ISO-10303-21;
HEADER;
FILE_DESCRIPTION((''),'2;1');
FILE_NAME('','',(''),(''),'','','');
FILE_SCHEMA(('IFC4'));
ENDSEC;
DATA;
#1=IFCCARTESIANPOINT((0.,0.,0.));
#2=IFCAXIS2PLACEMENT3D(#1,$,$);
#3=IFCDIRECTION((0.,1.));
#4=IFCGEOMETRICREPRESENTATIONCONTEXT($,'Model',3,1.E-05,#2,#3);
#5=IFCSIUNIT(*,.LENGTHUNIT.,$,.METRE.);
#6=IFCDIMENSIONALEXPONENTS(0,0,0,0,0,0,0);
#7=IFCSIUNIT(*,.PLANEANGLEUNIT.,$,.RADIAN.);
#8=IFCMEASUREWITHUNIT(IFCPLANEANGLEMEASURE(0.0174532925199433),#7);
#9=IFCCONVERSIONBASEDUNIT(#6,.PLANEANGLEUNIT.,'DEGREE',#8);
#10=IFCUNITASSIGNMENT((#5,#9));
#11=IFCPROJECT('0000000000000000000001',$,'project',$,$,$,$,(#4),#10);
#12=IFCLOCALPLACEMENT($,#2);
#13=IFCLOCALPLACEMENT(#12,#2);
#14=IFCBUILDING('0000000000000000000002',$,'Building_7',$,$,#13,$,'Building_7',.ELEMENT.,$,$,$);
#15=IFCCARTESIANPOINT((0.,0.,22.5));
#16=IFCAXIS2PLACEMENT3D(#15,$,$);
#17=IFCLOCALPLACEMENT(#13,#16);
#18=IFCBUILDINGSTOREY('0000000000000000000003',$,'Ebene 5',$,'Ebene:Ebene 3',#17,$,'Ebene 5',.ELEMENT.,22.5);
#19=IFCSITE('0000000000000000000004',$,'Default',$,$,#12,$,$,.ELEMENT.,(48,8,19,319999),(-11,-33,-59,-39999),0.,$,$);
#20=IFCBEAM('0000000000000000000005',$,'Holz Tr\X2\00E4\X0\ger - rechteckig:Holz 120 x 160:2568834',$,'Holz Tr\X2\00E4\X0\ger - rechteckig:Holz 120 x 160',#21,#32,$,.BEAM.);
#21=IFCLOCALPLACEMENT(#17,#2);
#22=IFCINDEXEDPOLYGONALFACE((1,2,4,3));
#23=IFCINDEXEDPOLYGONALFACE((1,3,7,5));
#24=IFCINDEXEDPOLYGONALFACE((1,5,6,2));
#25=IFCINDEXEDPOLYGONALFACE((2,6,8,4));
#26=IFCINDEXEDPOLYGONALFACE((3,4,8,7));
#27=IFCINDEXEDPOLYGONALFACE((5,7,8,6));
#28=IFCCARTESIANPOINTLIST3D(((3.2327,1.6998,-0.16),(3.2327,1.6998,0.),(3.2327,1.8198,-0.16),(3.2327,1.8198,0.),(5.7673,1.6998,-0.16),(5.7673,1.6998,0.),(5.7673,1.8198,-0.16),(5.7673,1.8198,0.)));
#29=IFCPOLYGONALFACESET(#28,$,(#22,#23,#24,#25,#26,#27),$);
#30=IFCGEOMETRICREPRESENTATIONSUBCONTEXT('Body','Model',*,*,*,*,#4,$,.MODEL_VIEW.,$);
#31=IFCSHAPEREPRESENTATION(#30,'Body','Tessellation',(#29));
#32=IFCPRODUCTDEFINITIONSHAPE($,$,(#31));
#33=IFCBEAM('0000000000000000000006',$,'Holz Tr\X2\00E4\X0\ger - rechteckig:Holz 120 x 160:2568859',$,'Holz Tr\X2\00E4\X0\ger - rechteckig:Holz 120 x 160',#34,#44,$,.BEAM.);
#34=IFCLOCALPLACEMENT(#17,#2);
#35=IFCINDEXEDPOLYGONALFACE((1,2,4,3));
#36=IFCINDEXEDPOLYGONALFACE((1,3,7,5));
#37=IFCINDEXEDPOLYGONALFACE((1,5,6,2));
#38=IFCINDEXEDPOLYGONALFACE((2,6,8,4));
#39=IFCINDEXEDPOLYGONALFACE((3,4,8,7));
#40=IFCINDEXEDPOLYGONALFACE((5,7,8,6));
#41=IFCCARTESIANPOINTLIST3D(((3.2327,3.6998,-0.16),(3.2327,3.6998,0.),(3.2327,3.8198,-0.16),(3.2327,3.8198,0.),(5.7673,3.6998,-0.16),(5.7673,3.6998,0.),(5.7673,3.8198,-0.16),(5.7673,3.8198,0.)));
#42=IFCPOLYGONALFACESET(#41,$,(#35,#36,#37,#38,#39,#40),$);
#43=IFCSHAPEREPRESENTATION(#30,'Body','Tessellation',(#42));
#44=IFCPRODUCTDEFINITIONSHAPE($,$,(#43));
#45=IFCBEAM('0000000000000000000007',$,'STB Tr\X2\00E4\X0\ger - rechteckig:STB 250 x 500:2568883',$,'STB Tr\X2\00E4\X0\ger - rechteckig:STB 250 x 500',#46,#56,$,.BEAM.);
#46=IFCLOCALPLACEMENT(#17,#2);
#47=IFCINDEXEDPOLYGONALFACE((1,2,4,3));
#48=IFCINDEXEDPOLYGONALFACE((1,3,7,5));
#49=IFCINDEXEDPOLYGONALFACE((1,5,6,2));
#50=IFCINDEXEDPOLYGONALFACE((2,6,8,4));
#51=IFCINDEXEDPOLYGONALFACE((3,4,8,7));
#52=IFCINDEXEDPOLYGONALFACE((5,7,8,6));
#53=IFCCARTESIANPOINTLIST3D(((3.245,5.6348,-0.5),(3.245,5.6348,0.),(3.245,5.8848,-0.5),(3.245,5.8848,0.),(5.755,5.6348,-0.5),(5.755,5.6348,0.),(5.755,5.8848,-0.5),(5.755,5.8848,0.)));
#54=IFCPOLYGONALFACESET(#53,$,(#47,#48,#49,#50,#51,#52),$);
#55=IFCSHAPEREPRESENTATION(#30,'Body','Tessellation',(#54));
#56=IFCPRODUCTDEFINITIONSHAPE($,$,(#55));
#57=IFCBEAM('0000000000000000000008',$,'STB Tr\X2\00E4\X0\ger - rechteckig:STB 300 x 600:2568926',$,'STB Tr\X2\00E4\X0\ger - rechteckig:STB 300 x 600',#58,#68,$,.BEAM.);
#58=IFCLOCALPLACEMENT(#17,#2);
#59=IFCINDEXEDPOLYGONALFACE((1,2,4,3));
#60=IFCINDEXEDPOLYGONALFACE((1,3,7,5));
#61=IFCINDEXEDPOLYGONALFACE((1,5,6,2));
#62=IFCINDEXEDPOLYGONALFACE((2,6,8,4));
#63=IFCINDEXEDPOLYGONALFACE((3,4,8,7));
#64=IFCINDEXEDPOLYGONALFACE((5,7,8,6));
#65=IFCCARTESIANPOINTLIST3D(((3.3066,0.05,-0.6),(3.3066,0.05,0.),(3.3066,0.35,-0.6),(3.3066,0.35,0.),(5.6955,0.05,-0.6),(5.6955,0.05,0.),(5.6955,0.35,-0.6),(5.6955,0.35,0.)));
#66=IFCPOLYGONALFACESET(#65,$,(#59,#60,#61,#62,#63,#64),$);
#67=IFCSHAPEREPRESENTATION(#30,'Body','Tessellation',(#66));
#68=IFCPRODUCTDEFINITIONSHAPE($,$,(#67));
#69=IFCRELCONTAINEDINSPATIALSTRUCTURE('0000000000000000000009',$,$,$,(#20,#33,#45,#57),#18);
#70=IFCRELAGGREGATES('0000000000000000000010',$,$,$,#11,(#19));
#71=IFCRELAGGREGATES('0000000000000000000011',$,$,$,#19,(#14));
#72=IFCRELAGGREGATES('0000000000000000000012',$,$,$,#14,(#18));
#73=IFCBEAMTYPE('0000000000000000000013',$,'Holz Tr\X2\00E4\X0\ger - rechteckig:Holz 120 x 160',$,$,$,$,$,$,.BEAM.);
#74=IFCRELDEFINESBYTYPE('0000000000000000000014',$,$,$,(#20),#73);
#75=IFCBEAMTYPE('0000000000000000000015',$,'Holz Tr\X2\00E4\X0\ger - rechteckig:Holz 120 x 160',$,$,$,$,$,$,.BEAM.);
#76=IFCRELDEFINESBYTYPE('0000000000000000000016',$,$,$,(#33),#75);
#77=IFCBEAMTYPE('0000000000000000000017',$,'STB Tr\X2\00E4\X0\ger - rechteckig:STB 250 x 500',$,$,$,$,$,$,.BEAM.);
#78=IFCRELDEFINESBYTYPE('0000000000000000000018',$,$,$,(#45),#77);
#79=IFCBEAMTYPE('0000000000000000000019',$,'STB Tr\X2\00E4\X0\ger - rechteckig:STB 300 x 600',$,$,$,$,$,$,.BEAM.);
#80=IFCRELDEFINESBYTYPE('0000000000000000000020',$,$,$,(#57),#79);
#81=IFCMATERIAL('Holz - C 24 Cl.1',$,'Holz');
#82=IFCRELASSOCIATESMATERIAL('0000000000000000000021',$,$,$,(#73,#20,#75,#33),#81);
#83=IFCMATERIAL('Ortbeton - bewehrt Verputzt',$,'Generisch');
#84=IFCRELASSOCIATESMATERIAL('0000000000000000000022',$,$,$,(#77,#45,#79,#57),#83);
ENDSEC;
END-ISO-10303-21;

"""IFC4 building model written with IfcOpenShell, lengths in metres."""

from ifc_helpers import new_model, entity, si_unit, converted_unit, direction, frame, origin, place, context, subcontext, project, spatial, indexed_curve, outline, extrude, source, transform, mapped, material, type_object, type_shapes, element, save


model = new_model("IFC4")

# Units and contexts
model_context = context("Model", 3, precision=1e-05, world=origin(), true_north=direction((0.0, 1.0)))
body_context = subcontext(model_context, "Body", "Model", "MODEL_VIEW")
ifc_project = project(units=[si_unit("LENGTHUNIT", "METRE"), converted_unit("PLANEANGLEUNIT", "DEGREE", entity("IfcPlaneAngleMeasure", 0.0174532925199433), si_unit("PLANEANGLEUNIT", "RADIAN"), dimensions=[0, 0, 0, 0, 0, 0, 0])], contexts=[model_context])

# Site, building, storey
site_placement = place(None, origin())
site = spatial("IfcSite", under=ifc_project, at=site_placement, Name="Default", CompositionType="ELEMENT", RefLatitude=(48, 8, 19, 319999), RefLongitude=(-11, -33, -59, -39999), RefElevation=0.0)
building_placement = place(site_placement, origin())
building = spatial("IfcBuilding", under=site, at=building_placement, Name="Building_7", LongName="Building_7", CompositionType="ELEMENT")
storey_placement = place(building_placement, frame((0.0, 0.0, 22.5)))
storey = spatial("IfcBuildingStorey", under=building, at=storey_placement, Name="Ebene 5", ObjectType="Ebene:Ebene 3", LongName="Ebene 5", CompositionType="ELEMENT", Elevation=22.5)

# Beams
ifc_material_1 = material(Name="Holz - C 24 Cl.1", Category="Holz")
beam_type_1 = type_object("IfcBeamType", Name="Holz Träger - rechteckig:Holz 120 x 160", PredefinedType="BEAM", material=ifc_material_1)
shared_shape_1 = source(origin(), body_context, "Body", "SweptSolid", [
    extrude(outline(indexed_curve([(-0.08, -0.06), (0.08, -0.06), (0.08, 0.06), (-0.08, 0.06), (-0.08, -0.06)], self_intersect=False)), frame((3.2327, 1.7598, 22.42), z_axis=(1.0, 0.0, 0.0), x_axis=(0.0, 0.0, -1.0)), (0.0, 0.0, 1.0), 2.5346),
])
type_shapes(beam_type_1, [shared_shape_1])
beam_1_placement = place(storey_placement, frame((0.0, 0.0, -22.5)))
element("IfcBeam", 1, at=beam_1_placement, inside=storey, type_object=beam_type_1, material=ifc_material_1, Name="Holz Träger - rechteckig:Holz 120 x 160:2568834", ObjectType="Holz Träger - rechteckig:Holz 120 x 160", PredefinedType="BEAM", context=body_context, shape_type="MappedRepresentation", body=[
    mapped(shared_shape_1, transform((0.0, 0.0, 0.0), scale=1.0)),
])
beam_type_2 = type_object("IfcBeamType", Name="Holz Träger - rechteckig:Holz 120 x 160", PredefinedType="BEAM", material=ifc_material_1)
shared_shape_2 = source(origin(), body_context, "Body", "SweptSolid", [
    extrude(outline(indexed_curve([(-0.08, -0.06), (0.08, -0.06), (0.08, 0.06), (-0.08, 0.06), (-0.08, -0.06)], self_intersect=False)), frame((3.2327, 3.7598, 22.42), z_axis=(1.0, 0.0, 0.0), x_axis=(0.0, 0.0, -1.0)), (0.0, 0.0, 1.0), 2.5346),
])
type_shapes(beam_type_2, [shared_shape_2])
beam_2_placement = place(storey_placement, frame((0.0, 0.0, -22.5)))
element("IfcBeam", 2, at=beam_2_placement, inside=storey, type_object=beam_type_2, material=ifc_material_1, Name="Holz Träger - rechteckig:Holz 120 x 160:2568859", ObjectType="Holz Träger - rechteckig:Holz 120 x 160", PredefinedType="BEAM", context=body_context, shape_type="MappedRepresentation", body=[
    mapped(shared_shape_2, transform((0.0, 0.0, 0.0), scale=1.0)),
])
ifc_material_2 = material(Name="Ortbeton - bewehrt Verputzt", Category="Generisch")
beam_type_3 = type_object("IfcBeamType", Name="STB Träger - rechteckig:STB 250 x 500", PredefinedType="BEAM", material=ifc_material_2)
shared_shape_3 = source(origin(), body_context, "Body", "SweptSolid", [
    extrude(outline(indexed_curve([(-0.25, -0.125), (0.25, -0.125), (0.25, 0.125), (-0.25, 0.125), (-0.25, -0.125)], self_intersect=False)), frame((5.755, 5.7598, 22.25), z_axis=(-1.0, 0.0, 0.0), x_axis=(0.0, 0.0, -1.0)), (0.0, 0.0, 1.0), 2.51),
])
type_shapes(beam_type_3, [shared_shape_3])
beam_3_placement = place(storey_placement, frame((0.0, 0.0, -22.5)))
element("IfcBeam", 3, at=beam_3_placement, inside=storey, type_object=beam_type_3, material=ifc_material_2, Name="STB Träger - rechteckig:STB 250 x 500:2568883", ObjectType="STB Träger - rechteckig:STB 250 x 500", PredefinedType="BEAM", context=body_context, shape_type="MappedRepresentation", body=[
    mapped(shared_shape_3, transform((0.0, 0.0, 0.0), scale=1.0)),
])
beam_type_4 = type_object("IfcBeamType", Name="STB Träger - rechteckig:STB 300 x 600", PredefinedType="BEAM", material=ifc_material_2)
shared_shape_4 = source(origin(), body_context, "Body", "SweptSolid", [
    extrude(outline(indexed_curve([(-0.3, -0.15), (0.3, -0.15), (0.3, 0.15), (-0.3, 0.15), (-0.3, -0.15)], self_intersect=False)), frame((3.3066, 0.2, 22.2), z_axis=(1.0, 0.0, 0.0), x_axis=(0.0, 0.0, -1.0)), (0.0, 0.0, 1.0), 2.3889),
])
type_shapes(beam_type_4, [shared_shape_4])
beam_4_placement = place(storey_placement, frame((0.0, 0.0, -22.5)))
element("IfcBeam", 4, at=beam_4_placement, inside=storey, type_object=beam_type_4, material=ifc_material_2, Name="STB Träger - rechteckig:STB 300 x 600:2568926", ObjectType="STB Träger - rechteckig:STB 300 x 600", PredefinedType="BEAM", context=body_context, shape_type="MappedRepresentation", body=[
    mapped(shared_shape_4, transform((0.0, 0.0, 0.0), scale=1.0)),
])

save(model, "model.ifc")
